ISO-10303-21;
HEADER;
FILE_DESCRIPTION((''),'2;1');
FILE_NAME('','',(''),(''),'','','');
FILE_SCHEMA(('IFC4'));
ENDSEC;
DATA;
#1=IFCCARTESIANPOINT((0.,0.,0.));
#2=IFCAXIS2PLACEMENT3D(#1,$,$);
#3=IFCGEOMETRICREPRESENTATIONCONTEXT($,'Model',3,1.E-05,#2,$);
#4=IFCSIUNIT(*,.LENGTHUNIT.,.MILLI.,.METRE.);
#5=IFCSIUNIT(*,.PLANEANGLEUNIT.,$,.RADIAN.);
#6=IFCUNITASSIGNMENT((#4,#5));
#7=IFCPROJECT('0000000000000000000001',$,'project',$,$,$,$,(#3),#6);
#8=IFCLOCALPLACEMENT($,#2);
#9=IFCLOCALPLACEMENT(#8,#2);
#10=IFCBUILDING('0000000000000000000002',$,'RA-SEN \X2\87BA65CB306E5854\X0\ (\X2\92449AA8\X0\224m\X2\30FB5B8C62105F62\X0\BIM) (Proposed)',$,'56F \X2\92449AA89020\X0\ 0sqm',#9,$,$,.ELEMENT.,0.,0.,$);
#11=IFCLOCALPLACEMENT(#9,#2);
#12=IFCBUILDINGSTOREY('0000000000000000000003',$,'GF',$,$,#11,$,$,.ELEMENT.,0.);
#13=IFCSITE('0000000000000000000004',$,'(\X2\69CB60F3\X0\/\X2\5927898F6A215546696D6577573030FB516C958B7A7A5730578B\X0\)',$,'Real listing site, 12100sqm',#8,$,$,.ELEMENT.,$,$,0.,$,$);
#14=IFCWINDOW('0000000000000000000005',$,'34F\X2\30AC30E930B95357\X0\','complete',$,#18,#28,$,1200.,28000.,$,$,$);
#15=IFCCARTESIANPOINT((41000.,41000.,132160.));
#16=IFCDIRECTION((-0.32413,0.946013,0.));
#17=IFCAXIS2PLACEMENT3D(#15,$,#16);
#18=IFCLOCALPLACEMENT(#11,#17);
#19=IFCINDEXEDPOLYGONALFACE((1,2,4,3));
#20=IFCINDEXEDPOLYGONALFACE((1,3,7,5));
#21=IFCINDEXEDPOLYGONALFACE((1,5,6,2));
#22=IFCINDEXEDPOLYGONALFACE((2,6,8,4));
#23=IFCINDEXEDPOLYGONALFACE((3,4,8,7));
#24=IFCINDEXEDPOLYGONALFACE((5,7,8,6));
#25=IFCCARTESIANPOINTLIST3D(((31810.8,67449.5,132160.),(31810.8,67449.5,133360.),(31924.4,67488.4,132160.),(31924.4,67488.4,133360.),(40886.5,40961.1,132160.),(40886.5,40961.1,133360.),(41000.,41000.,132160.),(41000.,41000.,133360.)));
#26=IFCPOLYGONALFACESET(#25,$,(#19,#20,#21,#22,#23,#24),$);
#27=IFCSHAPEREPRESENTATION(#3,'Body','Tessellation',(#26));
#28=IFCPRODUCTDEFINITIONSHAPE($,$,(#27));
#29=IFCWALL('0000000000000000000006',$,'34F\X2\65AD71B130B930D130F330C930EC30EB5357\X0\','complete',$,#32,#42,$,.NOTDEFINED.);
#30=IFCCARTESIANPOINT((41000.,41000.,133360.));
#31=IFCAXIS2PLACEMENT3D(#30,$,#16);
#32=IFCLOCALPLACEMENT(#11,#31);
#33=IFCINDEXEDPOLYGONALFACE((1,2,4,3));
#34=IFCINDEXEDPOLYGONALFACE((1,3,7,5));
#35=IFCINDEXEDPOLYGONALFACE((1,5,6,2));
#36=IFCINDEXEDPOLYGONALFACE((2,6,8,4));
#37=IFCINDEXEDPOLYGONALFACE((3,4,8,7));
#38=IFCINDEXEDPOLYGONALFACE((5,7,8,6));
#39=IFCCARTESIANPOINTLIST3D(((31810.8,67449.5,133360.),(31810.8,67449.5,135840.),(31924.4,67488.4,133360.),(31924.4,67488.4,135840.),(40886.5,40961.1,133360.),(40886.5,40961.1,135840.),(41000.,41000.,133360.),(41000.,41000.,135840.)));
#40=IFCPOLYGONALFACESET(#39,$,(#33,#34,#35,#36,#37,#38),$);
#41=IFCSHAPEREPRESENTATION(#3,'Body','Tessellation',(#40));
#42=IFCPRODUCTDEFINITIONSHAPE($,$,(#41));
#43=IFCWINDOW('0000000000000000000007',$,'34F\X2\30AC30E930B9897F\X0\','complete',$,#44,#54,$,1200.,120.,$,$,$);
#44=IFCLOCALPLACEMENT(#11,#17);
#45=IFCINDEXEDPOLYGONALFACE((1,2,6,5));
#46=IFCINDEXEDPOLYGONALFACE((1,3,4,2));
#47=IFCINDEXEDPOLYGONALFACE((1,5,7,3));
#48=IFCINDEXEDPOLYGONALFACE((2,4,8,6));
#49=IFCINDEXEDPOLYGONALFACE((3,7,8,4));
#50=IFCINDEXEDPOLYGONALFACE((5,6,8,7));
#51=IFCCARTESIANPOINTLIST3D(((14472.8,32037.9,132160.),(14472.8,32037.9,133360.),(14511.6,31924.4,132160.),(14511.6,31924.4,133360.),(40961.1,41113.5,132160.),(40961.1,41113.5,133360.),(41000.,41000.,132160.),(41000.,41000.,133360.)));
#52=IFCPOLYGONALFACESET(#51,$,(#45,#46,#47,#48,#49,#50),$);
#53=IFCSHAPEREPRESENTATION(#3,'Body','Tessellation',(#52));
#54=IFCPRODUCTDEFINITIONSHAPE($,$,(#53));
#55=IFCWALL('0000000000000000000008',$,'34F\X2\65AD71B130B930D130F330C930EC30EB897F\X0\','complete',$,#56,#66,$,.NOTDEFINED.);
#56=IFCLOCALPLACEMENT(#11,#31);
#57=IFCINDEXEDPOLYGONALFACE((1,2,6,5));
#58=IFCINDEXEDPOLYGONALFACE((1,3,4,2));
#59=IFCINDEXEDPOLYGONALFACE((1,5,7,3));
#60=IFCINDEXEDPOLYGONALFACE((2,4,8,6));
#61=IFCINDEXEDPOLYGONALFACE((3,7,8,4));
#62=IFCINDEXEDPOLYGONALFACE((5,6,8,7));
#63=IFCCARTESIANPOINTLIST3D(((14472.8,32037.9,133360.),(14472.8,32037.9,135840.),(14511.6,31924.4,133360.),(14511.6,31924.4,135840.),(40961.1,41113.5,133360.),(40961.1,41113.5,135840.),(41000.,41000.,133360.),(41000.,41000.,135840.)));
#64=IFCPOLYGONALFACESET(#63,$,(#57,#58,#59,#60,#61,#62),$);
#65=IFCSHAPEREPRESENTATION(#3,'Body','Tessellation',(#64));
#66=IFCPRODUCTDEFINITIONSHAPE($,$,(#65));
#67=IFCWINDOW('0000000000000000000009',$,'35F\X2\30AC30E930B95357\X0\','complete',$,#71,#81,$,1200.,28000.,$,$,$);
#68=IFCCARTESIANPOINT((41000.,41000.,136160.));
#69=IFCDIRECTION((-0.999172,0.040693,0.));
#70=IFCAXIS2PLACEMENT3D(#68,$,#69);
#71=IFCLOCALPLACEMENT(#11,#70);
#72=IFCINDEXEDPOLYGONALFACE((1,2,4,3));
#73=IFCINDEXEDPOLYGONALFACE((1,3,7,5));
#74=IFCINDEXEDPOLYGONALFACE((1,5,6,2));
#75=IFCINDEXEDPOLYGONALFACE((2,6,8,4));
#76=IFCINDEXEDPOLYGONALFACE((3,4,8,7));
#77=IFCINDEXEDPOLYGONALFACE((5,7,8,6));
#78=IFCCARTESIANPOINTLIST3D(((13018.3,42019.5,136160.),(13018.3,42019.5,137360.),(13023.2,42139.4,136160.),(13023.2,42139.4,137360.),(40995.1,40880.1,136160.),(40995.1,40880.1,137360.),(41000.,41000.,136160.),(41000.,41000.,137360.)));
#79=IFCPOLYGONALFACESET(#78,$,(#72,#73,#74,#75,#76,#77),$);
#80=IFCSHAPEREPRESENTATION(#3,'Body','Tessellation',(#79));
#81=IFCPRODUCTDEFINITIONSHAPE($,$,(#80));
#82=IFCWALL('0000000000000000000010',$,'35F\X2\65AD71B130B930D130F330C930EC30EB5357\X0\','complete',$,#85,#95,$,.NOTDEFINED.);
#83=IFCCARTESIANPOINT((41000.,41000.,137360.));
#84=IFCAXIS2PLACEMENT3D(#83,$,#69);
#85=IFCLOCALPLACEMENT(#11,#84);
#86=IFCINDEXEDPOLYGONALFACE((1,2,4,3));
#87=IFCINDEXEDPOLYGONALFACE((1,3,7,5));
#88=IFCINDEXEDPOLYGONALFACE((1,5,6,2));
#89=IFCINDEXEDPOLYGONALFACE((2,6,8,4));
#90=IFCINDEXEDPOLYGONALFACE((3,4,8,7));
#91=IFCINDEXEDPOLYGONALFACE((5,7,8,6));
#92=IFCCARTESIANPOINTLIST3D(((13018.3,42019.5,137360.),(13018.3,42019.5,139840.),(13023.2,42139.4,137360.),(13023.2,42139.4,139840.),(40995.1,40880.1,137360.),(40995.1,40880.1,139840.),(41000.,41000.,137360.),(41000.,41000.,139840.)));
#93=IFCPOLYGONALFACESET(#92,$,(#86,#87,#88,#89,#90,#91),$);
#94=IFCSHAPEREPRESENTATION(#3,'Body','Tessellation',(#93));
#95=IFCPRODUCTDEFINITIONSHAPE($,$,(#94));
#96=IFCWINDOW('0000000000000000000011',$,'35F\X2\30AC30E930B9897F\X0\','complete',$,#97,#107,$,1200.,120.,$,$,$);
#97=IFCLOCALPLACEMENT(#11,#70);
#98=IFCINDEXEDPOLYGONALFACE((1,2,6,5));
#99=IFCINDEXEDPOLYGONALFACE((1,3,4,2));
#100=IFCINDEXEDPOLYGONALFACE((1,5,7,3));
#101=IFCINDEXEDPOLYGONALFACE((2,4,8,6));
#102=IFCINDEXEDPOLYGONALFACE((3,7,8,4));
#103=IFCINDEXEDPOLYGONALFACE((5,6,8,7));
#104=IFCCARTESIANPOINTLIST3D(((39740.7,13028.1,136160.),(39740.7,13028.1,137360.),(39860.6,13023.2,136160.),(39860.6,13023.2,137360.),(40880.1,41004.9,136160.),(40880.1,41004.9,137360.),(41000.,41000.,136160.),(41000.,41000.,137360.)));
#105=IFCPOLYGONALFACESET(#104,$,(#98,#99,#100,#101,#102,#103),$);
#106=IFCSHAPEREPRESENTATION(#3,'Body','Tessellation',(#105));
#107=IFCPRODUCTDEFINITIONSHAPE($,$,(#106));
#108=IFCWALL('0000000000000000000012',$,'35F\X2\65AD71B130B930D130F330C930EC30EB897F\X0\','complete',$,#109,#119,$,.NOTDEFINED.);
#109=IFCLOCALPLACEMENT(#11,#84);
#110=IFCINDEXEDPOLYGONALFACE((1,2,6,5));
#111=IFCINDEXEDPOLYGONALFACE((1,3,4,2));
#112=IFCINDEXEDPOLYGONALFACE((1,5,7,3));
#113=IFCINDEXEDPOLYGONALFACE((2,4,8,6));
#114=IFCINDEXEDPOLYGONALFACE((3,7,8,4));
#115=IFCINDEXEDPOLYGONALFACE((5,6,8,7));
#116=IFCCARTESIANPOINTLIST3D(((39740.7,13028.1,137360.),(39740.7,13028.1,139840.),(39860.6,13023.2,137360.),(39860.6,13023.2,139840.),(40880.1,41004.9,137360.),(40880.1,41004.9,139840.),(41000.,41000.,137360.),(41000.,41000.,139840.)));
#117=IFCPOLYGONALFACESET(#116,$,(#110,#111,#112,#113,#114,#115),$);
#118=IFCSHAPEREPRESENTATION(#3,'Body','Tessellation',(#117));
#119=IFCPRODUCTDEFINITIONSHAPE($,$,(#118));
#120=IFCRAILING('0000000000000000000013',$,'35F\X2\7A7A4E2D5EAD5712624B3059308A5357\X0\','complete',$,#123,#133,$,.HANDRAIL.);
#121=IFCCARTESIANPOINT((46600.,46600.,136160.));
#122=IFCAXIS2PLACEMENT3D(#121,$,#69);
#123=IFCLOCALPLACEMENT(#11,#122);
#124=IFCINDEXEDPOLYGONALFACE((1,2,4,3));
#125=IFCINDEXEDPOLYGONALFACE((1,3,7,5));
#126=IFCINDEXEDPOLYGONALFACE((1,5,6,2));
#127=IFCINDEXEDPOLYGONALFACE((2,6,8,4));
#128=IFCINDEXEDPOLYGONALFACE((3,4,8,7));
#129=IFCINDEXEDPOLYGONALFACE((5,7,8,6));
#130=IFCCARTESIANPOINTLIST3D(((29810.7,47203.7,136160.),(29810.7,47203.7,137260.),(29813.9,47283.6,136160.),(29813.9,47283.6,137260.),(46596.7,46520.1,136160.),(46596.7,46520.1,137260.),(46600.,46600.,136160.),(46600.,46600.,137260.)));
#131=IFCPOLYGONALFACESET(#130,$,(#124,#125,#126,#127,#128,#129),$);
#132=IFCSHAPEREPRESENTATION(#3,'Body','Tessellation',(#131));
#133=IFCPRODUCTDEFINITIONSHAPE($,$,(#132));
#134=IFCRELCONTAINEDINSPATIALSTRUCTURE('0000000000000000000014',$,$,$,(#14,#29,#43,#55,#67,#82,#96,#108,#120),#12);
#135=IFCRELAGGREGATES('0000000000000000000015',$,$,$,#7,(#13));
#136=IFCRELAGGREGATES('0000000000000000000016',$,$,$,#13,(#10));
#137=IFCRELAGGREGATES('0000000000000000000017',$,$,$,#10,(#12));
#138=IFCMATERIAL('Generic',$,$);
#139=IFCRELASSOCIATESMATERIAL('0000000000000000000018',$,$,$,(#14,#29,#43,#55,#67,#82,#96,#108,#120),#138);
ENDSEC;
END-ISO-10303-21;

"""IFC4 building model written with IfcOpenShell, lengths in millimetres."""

from ifc_helpers import new_model, si_unit, frame, frame_2d, origin, place, context, project, spatial, rectangle, extrude, material, element, save


model = new_model("IFC4")

# Units and contexts
model_context = context("Model", 3, precision=1e-05, world=origin())
ifc_project = project(units=[si_unit("LENGTHUNIT", "METRE", prefix="MILLI"), si_unit("PLANEANGLEUNIT", "RADIAN")], contexts=[model_context])

# Site, building, storey
site_placement = place(None, origin())
site = spatial("IfcSite", under=ifc_project, at=site_placement, Name="(構想/大規模商業敷地・公開空地型)", ObjectType="Real listing site, 12100sqm", CompositionType="ELEMENT", RefElevation=0.0)
building_placement = place(site_placement, origin())
building = spatial("IfcBuilding", under=site, at=building_placement, Name="RA-SEN 螺旋の塔 (鉄骨224m・完成形BIM) (Proposed)", ObjectType="56F 鉄骨造 0sqm", CompositionType="ELEMENT", ElevationOfRefHeight=0.0, ElevationOfTerrain=0.0)
storey_placement = place(building_placement, origin())
storey = spatial("IfcBuildingStorey", under=building, at=storey_placement, Name="GF", CompositionType="ELEMENT", Elevation=0.0)

# Shared definitions
ifc_material = material(Name="Generic")

# Window
window_1_placement = place(storey_placement, frame((41000.0, 41000.0, 132160.0), x_axis=(-0.32413, 0.946013, 0.0)))
element("IfcWindow", 1, at=window_1_placement, inside=storey, material=ifc_material, Name="34Fガラス南", Description="complete", OverallHeight=1200.0, OverallWidth=28000.0, context=model_context, shape_type="SweptSolid", body=[
    extrude(rectangle(XDim=28000.0, YDim=120.0, at=frame_2d((14000.0, 60.0))), frame((41000.0, 41000.0, 132160.0), x_axis=(-0.32413, 0.946013, 0.0)), (0.0, 0.0, 1.0), 1200.0),
])

# Wall
wall_1_placement = place(storey_placement, frame((41000.0, 41000.0, 133360.0), x_axis=(-0.32413, 0.946013, 0.0)))
element("IfcWall", 2, at=wall_1_placement, inside=storey, material=ifc_material, Name="34F断熱スパンドレル南", Description="complete", PredefinedType="NOTDEFINED", context=model_context, shape_type="SweptSolid", body=[
    extrude(rectangle(XDim=28000.0, YDim=120.0, at=frame_2d((14000.0, 60.0))), frame((41000.0, 41000.0, 133360.0), x_axis=(-0.32413, 0.946013, 0.0)), (0.0, 0.0, 1.0), 2480.0),
])

# Window
window_2_placement = place(storey_placement, frame((41000.0, 41000.0, 132160.0), x_axis=(-0.32413, 0.946013, 0.0)))
element("IfcWindow", 3, at=window_2_placement, inside=storey, material=ifc_material, Name="34Fガラス西", Description="complete", OverallHeight=1200.0, OverallWidth=120.0, context=model_context, shape_type="SweptSolid", body=[
    extrude(rectangle(XDim=120.0, YDim=28000.0, at=frame_2d((60.0, 14000.0))), frame((41000.0, 41000.0, 132160.0), x_axis=(-0.32413, 0.946013, 0.0)), (0.0, 0.0, 1.0), 1200.0),
])

# Wall
wall_2_placement = place(storey_placement, frame((41000.0, 41000.0, 133360.0), x_axis=(-0.32413, 0.946013, 0.0)))
element("IfcWall", 4, at=wall_2_placement, inside=storey, material=ifc_material, Name="34F断熱スパンドレル西", Description="complete", PredefinedType="NOTDEFINED", context=model_context, shape_type="SweptSolid", body=[
    extrude(rectangle(XDim=120.0, YDim=28000.0, at=frame_2d((60.0, 14000.0))), frame((41000.0, 41000.0, 133360.0), x_axis=(-0.32413, 0.946013, 0.0)), (0.0, 0.0, 1.0), 2480.0),
])

# Window
window_3_placement = place(storey_placement, frame((41000.0, 41000.0, 136160.0), x_axis=(-0.999172, 0.040693, 0.0)))
element("IfcWindow", 5, at=window_3_placement, inside=storey, material=ifc_material, Name="35Fガラス南", Description="complete", OverallHeight=1200.0, OverallWidth=28000.0, context=model_context, shape_type="SweptSolid", body=[
    extrude(rectangle(XDim=28000.0, YDim=120.0, at=frame_2d((14000.0, 60.0))), frame((41000.0, 41000.0, 136160.0), x_axis=(-0.999172, 0.040693, 0.0)), (0.0, 0.0, 1.0), 1200.0),
])

# Wall
wall_3_placement = place(storey_placement, frame((41000.0, 41000.0, 137360.0), x_axis=(-0.999172, 0.040693, 0.0)))
element("IfcWall", 6, at=wall_3_placement, inside=storey, material=ifc_material, Name="35F断熱スパンドレル南", Description="complete", PredefinedType="NOTDEFINED", context=model_context, shape_type="SweptSolid", body=[
    extrude(rectangle(XDim=28000.0, YDim=120.0, at=frame_2d((14000.0, 60.0))), frame((41000.0, 41000.0, 137360.0), x_axis=(-0.999172, 0.040693, 0.0)), (0.0, 0.0, 1.0), 2480.0),
])

# Window
window_4_placement = place(storey_placement, frame((41000.0, 41000.0, 136160.0), x_axis=(-0.999172, 0.040693, 0.0)))
element("IfcWindow", 7, at=window_4_placement, inside=storey, material=ifc_material, Name="35Fガラス西", Description="complete", OverallHeight=1200.0, OverallWidth=120.0, context=model_context, shape_type="SweptSolid", body=[
    extrude(rectangle(XDim=120.0, YDim=28000.0, at=frame_2d((60.0, 14000.0))), frame((41000.0, 41000.0, 136160.0), x_axis=(-0.999172, 0.040693, 0.0)), (0.0, 0.0, 1.0), 1200.0),
])

# Wall
wall_4_placement = place(storey_placement, frame((41000.0, 41000.0, 137360.0), x_axis=(-0.999172, 0.040693, 0.0)))
element("IfcWall", 8, at=wall_4_placement, inside=storey, material=ifc_material, Name="35F断熱スパンドレル西", Description="complete", PredefinedType="NOTDEFINED", context=model_context, shape_type="SweptSolid", body=[
    extrude(rectangle(XDim=120.0, YDim=28000.0, at=frame_2d((60.0, 14000.0))), frame((41000.0, 41000.0, 137360.0), x_axis=(-0.999172, 0.040693, 0.0)), (0.0, 0.0, 1.0), 2480.0),
])

# Railing
railing_placement = place(storey_placement, frame((46600.0, 46600.0, 136160.0), x_axis=(-0.999172, 0.040693, 0.0)))
element("IfcRailing", 9, at=railing_placement, inside=storey, material=ifc_material, Name="35F空中庭園手すり南", Description="complete", PredefinedType="HANDRAIL", context=model_context, shape_type="SweptSolid", body=[
    extrude(rectangle(XDim=16800.0, YDim=80.0, at=frame_2d((8400.0, 40.0))), frame((46600.0, 46600.0, 136160.0), x_axis=(-0.999172, 0.040693, 0.0)), (0.0, 0.0, 1.0), 1100.0),
])

save(model, "model.ifc")
